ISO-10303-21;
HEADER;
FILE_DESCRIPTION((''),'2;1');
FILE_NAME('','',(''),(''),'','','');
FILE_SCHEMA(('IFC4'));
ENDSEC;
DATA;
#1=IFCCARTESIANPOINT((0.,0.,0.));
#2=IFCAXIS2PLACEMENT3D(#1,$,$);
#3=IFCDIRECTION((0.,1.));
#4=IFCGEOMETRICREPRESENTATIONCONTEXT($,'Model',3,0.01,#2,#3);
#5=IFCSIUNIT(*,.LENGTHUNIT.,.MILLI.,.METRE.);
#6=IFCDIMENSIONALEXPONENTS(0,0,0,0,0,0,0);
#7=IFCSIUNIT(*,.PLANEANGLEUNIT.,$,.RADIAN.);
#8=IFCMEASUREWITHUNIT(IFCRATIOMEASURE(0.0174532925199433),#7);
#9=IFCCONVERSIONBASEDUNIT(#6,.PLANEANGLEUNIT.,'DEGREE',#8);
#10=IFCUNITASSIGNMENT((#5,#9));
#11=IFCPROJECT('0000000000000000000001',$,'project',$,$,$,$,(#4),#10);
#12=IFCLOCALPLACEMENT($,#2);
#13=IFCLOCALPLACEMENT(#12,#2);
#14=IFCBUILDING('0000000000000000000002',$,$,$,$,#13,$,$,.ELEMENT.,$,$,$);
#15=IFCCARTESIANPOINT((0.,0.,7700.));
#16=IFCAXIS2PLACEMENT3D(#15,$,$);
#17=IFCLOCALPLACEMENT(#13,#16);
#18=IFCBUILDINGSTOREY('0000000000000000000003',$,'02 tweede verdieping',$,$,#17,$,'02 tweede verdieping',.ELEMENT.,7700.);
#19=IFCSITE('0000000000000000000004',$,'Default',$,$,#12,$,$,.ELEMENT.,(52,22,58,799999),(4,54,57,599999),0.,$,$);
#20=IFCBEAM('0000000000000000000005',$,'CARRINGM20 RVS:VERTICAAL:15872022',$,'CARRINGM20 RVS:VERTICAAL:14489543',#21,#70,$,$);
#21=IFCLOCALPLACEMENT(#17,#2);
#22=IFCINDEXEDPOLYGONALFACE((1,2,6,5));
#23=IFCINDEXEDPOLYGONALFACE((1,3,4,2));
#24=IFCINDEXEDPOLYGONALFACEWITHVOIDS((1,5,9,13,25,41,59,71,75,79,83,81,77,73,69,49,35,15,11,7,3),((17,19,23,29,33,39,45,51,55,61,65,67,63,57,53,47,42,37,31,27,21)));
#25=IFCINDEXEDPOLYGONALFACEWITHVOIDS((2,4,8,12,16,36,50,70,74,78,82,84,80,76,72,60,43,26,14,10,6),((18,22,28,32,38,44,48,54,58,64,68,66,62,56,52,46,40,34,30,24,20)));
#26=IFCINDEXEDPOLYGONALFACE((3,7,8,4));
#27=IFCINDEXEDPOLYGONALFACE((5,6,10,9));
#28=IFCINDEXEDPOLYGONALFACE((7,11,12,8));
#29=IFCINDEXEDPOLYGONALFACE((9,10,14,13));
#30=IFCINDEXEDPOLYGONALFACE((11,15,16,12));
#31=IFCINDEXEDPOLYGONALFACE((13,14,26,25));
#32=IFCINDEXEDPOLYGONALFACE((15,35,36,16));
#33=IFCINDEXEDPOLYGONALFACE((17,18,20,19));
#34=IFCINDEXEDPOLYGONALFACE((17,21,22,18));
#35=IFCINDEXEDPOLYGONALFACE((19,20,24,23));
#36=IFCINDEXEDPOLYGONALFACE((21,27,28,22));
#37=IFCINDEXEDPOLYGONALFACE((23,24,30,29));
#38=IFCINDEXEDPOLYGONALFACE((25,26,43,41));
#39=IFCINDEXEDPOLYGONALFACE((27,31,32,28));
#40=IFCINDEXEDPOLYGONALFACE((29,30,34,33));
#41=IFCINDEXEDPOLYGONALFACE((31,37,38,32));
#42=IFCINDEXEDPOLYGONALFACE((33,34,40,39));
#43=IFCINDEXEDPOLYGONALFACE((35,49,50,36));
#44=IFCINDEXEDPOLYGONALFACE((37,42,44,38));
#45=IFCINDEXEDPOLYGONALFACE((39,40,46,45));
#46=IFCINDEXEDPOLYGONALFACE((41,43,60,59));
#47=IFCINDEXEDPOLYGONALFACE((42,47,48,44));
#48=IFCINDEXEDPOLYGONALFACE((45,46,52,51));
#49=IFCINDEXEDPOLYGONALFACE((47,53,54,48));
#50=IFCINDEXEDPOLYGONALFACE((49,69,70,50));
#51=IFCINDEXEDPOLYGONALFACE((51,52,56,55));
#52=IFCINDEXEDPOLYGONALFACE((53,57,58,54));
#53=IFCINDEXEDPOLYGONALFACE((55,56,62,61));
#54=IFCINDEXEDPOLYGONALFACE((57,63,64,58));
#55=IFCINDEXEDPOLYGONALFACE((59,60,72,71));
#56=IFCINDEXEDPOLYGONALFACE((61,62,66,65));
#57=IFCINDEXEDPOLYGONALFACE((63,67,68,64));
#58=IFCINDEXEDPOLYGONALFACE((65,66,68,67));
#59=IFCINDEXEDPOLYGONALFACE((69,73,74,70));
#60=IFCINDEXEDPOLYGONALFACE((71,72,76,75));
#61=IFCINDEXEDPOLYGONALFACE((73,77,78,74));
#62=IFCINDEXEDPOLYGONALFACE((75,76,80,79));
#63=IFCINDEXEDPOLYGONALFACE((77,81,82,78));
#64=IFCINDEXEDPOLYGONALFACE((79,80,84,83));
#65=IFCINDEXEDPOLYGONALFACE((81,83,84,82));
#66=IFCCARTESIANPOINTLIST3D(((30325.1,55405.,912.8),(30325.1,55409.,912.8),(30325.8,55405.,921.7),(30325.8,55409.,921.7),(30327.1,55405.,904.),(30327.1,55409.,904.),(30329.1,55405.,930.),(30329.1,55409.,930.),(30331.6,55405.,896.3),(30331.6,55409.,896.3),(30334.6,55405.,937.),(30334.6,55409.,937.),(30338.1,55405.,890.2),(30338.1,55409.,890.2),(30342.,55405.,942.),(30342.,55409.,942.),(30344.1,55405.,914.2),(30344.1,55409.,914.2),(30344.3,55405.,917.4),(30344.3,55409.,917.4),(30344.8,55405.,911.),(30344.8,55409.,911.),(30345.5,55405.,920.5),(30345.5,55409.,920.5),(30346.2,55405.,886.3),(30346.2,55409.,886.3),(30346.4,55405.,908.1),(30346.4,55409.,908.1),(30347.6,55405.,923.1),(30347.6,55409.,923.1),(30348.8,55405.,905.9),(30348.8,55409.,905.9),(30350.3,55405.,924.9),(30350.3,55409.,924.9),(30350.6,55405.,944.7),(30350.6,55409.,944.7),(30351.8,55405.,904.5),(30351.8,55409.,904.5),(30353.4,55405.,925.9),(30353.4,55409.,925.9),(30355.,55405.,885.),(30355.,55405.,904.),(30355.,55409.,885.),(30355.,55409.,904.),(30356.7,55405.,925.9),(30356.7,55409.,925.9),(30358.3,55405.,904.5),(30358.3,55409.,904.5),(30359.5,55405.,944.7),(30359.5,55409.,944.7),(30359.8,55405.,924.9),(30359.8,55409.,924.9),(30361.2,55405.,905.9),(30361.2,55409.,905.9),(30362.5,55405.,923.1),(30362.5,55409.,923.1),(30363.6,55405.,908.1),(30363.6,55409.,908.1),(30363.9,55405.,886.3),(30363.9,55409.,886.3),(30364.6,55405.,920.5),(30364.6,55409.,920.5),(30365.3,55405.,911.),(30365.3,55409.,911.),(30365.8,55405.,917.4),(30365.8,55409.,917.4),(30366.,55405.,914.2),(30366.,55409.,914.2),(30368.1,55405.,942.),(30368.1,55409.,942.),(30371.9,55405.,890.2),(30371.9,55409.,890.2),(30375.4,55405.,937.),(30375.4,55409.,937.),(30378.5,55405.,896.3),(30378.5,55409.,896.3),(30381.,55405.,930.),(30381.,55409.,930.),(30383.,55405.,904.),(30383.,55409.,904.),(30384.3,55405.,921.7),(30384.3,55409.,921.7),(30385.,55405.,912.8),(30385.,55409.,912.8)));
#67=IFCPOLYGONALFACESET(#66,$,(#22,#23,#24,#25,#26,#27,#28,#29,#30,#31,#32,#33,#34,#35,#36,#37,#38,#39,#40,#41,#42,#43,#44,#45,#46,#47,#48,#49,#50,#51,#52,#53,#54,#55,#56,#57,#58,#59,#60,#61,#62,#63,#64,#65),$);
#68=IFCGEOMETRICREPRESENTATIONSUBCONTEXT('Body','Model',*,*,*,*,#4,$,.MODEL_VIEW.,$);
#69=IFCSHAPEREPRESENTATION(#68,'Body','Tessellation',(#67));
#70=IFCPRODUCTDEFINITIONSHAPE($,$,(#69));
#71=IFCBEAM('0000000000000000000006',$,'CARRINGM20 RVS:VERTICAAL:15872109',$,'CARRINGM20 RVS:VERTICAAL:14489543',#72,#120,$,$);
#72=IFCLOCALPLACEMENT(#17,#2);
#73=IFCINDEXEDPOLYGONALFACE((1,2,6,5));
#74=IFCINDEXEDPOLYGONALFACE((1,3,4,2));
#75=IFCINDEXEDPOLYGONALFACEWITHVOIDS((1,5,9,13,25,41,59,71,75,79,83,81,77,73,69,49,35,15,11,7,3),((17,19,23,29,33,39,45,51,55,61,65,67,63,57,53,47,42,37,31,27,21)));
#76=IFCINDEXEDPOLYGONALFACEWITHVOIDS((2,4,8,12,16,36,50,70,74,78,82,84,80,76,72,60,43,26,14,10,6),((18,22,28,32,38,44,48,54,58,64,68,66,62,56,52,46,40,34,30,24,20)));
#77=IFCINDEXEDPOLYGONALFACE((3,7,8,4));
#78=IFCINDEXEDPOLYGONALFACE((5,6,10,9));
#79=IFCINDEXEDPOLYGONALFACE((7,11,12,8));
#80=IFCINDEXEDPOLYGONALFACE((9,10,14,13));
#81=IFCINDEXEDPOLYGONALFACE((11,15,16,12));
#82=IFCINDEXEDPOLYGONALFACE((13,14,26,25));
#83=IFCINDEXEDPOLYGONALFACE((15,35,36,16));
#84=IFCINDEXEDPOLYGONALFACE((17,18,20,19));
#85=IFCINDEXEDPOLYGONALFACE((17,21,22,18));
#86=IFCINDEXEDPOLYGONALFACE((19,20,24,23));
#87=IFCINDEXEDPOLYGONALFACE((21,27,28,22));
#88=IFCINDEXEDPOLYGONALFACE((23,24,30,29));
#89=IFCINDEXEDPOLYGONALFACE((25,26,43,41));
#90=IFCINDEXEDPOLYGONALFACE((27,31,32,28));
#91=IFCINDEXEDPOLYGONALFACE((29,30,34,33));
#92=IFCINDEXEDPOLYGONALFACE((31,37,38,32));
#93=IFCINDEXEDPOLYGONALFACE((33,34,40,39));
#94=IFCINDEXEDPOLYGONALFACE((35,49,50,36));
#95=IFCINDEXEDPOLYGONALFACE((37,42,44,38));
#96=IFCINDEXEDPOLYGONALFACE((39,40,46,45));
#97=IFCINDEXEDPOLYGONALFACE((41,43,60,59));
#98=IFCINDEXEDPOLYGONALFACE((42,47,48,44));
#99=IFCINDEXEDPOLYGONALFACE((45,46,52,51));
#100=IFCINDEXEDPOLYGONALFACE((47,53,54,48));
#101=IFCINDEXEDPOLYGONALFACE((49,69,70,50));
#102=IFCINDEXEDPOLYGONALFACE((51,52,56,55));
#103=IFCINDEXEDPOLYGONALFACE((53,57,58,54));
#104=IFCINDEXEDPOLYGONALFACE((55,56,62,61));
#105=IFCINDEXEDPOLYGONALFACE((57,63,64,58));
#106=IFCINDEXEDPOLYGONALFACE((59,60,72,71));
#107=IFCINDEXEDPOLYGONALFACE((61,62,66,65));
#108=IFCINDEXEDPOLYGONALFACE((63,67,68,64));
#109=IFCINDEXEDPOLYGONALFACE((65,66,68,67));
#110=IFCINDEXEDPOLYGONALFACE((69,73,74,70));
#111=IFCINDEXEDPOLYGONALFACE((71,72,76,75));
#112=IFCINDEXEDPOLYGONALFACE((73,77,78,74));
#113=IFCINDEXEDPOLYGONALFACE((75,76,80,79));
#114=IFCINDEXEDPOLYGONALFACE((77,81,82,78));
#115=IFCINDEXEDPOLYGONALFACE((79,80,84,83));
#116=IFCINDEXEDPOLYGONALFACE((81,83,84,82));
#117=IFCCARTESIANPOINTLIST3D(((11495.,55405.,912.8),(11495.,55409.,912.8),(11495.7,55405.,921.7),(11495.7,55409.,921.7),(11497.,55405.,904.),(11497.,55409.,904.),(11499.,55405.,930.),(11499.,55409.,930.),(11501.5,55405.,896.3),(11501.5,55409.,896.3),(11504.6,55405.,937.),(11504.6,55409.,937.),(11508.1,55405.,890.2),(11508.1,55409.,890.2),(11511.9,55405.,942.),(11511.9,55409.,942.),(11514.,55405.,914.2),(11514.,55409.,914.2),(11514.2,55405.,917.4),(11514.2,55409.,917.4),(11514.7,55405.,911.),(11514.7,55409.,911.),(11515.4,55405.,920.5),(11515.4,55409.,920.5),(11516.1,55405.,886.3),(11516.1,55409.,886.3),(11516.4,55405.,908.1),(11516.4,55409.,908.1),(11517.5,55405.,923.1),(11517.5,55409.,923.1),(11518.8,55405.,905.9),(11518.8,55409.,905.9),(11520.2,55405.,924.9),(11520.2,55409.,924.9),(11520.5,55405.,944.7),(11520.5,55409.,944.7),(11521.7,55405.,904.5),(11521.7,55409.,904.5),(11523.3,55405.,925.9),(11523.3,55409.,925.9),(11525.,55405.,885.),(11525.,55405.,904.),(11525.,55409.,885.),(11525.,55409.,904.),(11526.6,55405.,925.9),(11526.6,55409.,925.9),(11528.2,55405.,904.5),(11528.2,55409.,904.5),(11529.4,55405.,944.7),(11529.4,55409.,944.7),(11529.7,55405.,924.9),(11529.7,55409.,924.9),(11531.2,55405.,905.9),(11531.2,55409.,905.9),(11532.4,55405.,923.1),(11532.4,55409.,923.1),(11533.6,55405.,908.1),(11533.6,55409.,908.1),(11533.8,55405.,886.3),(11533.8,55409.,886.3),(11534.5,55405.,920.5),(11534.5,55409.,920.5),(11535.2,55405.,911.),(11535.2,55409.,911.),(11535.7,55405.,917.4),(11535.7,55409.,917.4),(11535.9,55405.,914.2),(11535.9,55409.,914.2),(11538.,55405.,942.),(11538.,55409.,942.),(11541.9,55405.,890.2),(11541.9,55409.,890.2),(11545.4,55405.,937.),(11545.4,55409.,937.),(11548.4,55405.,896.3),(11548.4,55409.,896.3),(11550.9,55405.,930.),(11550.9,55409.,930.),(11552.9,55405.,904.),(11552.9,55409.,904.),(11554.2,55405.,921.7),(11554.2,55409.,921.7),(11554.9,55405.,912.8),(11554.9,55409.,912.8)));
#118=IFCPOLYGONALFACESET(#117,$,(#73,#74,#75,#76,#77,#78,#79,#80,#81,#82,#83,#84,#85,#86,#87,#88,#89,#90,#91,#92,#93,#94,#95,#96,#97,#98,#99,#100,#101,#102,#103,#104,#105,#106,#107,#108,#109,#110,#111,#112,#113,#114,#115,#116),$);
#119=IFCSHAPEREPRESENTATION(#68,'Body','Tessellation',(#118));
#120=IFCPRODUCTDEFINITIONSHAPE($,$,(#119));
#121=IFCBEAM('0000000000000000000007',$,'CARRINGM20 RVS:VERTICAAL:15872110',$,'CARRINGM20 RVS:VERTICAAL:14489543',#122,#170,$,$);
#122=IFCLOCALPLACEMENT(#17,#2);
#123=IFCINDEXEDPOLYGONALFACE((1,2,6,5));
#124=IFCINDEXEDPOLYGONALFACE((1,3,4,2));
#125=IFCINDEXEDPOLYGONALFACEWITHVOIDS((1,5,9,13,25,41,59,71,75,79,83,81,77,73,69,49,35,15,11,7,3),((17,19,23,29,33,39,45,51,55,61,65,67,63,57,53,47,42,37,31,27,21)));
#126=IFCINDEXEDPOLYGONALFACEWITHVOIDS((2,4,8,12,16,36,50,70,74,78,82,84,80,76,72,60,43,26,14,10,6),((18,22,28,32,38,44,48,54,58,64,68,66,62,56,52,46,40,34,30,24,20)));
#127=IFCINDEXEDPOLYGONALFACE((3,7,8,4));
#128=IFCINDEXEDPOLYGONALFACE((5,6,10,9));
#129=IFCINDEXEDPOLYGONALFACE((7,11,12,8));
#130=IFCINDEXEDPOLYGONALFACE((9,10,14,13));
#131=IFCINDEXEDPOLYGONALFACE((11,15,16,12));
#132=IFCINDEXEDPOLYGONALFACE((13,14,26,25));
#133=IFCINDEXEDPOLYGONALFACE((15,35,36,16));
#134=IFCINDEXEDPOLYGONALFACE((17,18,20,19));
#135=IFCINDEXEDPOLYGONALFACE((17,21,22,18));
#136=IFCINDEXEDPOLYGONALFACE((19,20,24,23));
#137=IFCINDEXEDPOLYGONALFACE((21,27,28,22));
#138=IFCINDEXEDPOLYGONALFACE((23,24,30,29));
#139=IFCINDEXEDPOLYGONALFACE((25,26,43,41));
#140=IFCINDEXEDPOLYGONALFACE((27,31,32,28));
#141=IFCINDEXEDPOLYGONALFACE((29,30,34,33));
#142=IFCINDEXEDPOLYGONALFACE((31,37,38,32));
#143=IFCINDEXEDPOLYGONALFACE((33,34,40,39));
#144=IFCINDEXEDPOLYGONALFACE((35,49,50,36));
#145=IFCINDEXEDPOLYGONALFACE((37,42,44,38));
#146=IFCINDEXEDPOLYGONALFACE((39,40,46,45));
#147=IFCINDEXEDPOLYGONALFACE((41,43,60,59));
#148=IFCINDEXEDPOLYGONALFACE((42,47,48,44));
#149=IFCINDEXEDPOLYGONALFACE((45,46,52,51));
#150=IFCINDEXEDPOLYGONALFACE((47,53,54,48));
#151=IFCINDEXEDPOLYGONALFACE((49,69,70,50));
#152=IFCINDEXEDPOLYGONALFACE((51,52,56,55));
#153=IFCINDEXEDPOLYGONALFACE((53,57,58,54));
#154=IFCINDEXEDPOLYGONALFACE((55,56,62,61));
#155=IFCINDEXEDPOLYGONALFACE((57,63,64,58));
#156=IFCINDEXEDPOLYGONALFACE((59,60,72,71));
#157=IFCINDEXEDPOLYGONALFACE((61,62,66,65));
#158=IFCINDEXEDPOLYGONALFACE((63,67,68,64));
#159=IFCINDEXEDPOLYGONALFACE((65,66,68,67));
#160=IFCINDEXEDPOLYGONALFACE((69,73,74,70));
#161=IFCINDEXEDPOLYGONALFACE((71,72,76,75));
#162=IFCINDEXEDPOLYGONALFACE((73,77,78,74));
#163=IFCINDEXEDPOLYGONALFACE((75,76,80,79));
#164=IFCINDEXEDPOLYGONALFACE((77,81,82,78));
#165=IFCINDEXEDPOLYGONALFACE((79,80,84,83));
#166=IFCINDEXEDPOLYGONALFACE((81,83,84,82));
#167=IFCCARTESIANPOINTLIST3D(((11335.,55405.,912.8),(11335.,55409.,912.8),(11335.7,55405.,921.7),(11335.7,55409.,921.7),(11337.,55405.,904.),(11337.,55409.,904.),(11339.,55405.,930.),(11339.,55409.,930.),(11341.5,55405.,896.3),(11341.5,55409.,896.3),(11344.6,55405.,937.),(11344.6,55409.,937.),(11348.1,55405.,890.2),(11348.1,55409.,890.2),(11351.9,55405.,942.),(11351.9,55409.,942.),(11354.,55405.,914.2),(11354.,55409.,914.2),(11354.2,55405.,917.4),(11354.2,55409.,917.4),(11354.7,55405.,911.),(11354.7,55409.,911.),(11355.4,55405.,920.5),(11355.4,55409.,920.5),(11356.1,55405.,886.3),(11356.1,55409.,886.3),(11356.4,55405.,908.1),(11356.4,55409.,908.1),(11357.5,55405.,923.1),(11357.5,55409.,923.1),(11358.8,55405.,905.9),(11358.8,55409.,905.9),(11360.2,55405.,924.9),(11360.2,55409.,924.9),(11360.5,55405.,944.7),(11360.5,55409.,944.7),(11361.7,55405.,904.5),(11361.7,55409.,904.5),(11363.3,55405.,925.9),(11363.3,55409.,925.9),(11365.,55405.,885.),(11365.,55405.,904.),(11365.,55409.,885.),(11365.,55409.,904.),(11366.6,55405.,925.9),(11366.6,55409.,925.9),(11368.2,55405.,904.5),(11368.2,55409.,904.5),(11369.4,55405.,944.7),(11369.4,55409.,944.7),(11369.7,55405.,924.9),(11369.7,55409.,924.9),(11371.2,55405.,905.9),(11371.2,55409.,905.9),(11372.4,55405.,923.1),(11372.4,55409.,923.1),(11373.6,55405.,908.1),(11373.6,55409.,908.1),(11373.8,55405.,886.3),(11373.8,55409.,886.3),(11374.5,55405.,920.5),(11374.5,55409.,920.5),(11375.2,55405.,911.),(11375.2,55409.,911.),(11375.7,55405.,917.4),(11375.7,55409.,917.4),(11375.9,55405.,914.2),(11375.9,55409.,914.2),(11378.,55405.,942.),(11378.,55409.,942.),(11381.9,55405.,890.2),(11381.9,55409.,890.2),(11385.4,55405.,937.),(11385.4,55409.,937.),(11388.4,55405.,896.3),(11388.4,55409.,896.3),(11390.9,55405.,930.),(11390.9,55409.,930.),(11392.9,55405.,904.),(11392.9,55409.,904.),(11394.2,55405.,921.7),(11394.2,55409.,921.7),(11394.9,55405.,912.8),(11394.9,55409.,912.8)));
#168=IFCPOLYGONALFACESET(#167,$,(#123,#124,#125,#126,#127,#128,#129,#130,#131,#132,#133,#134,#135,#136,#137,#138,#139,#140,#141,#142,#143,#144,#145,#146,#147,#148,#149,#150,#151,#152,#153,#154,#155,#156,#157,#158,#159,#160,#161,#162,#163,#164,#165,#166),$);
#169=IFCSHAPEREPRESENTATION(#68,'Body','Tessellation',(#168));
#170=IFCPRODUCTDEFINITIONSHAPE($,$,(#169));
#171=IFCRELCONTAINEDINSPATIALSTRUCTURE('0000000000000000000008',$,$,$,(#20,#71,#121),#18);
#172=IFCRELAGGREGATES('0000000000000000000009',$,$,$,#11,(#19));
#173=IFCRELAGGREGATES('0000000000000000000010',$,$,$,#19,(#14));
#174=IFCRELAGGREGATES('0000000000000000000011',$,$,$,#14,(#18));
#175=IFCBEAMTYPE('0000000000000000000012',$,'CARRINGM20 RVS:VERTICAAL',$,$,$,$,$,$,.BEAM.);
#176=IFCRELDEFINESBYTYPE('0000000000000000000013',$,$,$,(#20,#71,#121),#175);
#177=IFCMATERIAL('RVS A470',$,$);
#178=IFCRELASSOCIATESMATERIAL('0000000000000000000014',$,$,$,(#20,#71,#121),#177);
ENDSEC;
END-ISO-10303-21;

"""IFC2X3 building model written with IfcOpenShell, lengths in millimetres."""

from ifc_helpers import new_model, entity, si_unit, converted_unit, direction, frame, origin, origin_2d_with_axis, place, context, subcontext, project, spatial, hollow_circle, extrude, material, type_object, element, save


model = new_model("IFC2X3")

# Units and contexts
model_context = context("Model", 3, precision=0.01, world=origin(), true_north=direction((0.0, 1.0)))
body_context = subcontext(model_context, "Body", "Model", "MODEL_VIEW")
ifc_project = project(units=[si_unit("LENGTHUNIT", "METRE", prefix="MILLI"), converted_unit("PLANEANGLEUNIT", "DEGREE", entity("IfcRatioMeasure", 0.0174532925199433), si_unit("PLANEANGLEUNIT", "RADIAN"), dimensions=[0, 0, 0, 0, 0, 0, 0])], contexts=[model_context])

# Site, building, storey
site_placement = place(None, origin())
site = spatial("IfcSite", under=ifc_project, at=site_placement, Name="Default", CompositionType="ELEMENT", RefLatitude=(52, 22, 58, 799999), RefLongitude=(4, 54, 57, 599999), RefElevation=0.0)
building_placement = place(site_placement, origin())
building = spatial("IfcBuilding", under=site, at=building_placement, CompositionType="ELEMENT")
storey_placement = place(building_placement, frame((0.0, 0.0, 7700.0)))
storey = spatial("IfcBuildingStorey", under=building, at=storey_placement, Name="02 tweede verdieping", LongName="02 tweede verdieping", CompositionType="ELEMENT", Elevation=7700.0)

# Beams
ifc_material_1 = material(Name="RVS A470")
beam_type_1 = type_object("IfcBeamType", Name="CARRINGM20 RVS:VERTICAAL", PredefinedType="BEAM")
beam_1_placement = place(storey_placement, origin())
element("IfcBeam", 1, at=beam_1_placement, inside=storey, type_object=beam_type_1, material=ifc_material_1, Name="CARRINGM20 RVS:VERTICAAL:15872022", ObjectType="CARRINGM20 RVS:VERTICAAL:14489543", context=body_context, shape_type="SweptSolid", body=[
    extrude(hollow_circle(Radius=30.0, WallThickness=19.0, at=origin_2d_with_axis()), frame((30355.0, 55405.0, 915.0), z_axis=(0.0, 1.0, 0.0), x_axis=(0.0, 0.0, -1.0)), (0.0, 0.0, 1.0), 4.0),
])
beam_2_placement = place(storey_placement, origin())
element("IfcBeam", 2, at=beam_2_placement, inside=storey, type_object=beam_type_1, material=ifc_material_1, Name="CARRINGM20 RVS:VERTICAAL:15872109", ObjectType="CARRINGM20 RVS:VERTICAAL:14489543", context=body_context, shape_type="SweptSolid", body=[
    extrude(hollow_circle(Radius=30.0, WallThickness=19.0, at=origin_2d_with_axis()), frame((11525.0, 55405.0, 915.0), z_axis=(0.0, 1.0, 0.0), x_axis=(0.0, 0.0, -1.0)), (0.0, 0.0, 1.0), 4.0),
])
beam_3_placement = place(storey_placement, origin())
element("IfcBeam", 3, at=beam_3_placement, inside=storey, type_object=beam_type_1, material=ifc_material_1, Name="CARRINGM20 RVS:VERTICAAL:15872110", ObjectType="CARRINGM20 RVS:VERTICAAL:14489543", context=body_context, shape_type="SweptSolid", body=[
    extrude(hollow_circle(Radius=30.0, WallThickness=19.0, at=origin_2d_with_axis()), frame((11365.0, 55405.0, 915.0), z_axis=(0.0, 1.0, 0.0), x_axis=(0.0, 0.0, -1.0)), (0.0, 0.0, 1.0), 4.0),
])

save(model, "model.ifc")
